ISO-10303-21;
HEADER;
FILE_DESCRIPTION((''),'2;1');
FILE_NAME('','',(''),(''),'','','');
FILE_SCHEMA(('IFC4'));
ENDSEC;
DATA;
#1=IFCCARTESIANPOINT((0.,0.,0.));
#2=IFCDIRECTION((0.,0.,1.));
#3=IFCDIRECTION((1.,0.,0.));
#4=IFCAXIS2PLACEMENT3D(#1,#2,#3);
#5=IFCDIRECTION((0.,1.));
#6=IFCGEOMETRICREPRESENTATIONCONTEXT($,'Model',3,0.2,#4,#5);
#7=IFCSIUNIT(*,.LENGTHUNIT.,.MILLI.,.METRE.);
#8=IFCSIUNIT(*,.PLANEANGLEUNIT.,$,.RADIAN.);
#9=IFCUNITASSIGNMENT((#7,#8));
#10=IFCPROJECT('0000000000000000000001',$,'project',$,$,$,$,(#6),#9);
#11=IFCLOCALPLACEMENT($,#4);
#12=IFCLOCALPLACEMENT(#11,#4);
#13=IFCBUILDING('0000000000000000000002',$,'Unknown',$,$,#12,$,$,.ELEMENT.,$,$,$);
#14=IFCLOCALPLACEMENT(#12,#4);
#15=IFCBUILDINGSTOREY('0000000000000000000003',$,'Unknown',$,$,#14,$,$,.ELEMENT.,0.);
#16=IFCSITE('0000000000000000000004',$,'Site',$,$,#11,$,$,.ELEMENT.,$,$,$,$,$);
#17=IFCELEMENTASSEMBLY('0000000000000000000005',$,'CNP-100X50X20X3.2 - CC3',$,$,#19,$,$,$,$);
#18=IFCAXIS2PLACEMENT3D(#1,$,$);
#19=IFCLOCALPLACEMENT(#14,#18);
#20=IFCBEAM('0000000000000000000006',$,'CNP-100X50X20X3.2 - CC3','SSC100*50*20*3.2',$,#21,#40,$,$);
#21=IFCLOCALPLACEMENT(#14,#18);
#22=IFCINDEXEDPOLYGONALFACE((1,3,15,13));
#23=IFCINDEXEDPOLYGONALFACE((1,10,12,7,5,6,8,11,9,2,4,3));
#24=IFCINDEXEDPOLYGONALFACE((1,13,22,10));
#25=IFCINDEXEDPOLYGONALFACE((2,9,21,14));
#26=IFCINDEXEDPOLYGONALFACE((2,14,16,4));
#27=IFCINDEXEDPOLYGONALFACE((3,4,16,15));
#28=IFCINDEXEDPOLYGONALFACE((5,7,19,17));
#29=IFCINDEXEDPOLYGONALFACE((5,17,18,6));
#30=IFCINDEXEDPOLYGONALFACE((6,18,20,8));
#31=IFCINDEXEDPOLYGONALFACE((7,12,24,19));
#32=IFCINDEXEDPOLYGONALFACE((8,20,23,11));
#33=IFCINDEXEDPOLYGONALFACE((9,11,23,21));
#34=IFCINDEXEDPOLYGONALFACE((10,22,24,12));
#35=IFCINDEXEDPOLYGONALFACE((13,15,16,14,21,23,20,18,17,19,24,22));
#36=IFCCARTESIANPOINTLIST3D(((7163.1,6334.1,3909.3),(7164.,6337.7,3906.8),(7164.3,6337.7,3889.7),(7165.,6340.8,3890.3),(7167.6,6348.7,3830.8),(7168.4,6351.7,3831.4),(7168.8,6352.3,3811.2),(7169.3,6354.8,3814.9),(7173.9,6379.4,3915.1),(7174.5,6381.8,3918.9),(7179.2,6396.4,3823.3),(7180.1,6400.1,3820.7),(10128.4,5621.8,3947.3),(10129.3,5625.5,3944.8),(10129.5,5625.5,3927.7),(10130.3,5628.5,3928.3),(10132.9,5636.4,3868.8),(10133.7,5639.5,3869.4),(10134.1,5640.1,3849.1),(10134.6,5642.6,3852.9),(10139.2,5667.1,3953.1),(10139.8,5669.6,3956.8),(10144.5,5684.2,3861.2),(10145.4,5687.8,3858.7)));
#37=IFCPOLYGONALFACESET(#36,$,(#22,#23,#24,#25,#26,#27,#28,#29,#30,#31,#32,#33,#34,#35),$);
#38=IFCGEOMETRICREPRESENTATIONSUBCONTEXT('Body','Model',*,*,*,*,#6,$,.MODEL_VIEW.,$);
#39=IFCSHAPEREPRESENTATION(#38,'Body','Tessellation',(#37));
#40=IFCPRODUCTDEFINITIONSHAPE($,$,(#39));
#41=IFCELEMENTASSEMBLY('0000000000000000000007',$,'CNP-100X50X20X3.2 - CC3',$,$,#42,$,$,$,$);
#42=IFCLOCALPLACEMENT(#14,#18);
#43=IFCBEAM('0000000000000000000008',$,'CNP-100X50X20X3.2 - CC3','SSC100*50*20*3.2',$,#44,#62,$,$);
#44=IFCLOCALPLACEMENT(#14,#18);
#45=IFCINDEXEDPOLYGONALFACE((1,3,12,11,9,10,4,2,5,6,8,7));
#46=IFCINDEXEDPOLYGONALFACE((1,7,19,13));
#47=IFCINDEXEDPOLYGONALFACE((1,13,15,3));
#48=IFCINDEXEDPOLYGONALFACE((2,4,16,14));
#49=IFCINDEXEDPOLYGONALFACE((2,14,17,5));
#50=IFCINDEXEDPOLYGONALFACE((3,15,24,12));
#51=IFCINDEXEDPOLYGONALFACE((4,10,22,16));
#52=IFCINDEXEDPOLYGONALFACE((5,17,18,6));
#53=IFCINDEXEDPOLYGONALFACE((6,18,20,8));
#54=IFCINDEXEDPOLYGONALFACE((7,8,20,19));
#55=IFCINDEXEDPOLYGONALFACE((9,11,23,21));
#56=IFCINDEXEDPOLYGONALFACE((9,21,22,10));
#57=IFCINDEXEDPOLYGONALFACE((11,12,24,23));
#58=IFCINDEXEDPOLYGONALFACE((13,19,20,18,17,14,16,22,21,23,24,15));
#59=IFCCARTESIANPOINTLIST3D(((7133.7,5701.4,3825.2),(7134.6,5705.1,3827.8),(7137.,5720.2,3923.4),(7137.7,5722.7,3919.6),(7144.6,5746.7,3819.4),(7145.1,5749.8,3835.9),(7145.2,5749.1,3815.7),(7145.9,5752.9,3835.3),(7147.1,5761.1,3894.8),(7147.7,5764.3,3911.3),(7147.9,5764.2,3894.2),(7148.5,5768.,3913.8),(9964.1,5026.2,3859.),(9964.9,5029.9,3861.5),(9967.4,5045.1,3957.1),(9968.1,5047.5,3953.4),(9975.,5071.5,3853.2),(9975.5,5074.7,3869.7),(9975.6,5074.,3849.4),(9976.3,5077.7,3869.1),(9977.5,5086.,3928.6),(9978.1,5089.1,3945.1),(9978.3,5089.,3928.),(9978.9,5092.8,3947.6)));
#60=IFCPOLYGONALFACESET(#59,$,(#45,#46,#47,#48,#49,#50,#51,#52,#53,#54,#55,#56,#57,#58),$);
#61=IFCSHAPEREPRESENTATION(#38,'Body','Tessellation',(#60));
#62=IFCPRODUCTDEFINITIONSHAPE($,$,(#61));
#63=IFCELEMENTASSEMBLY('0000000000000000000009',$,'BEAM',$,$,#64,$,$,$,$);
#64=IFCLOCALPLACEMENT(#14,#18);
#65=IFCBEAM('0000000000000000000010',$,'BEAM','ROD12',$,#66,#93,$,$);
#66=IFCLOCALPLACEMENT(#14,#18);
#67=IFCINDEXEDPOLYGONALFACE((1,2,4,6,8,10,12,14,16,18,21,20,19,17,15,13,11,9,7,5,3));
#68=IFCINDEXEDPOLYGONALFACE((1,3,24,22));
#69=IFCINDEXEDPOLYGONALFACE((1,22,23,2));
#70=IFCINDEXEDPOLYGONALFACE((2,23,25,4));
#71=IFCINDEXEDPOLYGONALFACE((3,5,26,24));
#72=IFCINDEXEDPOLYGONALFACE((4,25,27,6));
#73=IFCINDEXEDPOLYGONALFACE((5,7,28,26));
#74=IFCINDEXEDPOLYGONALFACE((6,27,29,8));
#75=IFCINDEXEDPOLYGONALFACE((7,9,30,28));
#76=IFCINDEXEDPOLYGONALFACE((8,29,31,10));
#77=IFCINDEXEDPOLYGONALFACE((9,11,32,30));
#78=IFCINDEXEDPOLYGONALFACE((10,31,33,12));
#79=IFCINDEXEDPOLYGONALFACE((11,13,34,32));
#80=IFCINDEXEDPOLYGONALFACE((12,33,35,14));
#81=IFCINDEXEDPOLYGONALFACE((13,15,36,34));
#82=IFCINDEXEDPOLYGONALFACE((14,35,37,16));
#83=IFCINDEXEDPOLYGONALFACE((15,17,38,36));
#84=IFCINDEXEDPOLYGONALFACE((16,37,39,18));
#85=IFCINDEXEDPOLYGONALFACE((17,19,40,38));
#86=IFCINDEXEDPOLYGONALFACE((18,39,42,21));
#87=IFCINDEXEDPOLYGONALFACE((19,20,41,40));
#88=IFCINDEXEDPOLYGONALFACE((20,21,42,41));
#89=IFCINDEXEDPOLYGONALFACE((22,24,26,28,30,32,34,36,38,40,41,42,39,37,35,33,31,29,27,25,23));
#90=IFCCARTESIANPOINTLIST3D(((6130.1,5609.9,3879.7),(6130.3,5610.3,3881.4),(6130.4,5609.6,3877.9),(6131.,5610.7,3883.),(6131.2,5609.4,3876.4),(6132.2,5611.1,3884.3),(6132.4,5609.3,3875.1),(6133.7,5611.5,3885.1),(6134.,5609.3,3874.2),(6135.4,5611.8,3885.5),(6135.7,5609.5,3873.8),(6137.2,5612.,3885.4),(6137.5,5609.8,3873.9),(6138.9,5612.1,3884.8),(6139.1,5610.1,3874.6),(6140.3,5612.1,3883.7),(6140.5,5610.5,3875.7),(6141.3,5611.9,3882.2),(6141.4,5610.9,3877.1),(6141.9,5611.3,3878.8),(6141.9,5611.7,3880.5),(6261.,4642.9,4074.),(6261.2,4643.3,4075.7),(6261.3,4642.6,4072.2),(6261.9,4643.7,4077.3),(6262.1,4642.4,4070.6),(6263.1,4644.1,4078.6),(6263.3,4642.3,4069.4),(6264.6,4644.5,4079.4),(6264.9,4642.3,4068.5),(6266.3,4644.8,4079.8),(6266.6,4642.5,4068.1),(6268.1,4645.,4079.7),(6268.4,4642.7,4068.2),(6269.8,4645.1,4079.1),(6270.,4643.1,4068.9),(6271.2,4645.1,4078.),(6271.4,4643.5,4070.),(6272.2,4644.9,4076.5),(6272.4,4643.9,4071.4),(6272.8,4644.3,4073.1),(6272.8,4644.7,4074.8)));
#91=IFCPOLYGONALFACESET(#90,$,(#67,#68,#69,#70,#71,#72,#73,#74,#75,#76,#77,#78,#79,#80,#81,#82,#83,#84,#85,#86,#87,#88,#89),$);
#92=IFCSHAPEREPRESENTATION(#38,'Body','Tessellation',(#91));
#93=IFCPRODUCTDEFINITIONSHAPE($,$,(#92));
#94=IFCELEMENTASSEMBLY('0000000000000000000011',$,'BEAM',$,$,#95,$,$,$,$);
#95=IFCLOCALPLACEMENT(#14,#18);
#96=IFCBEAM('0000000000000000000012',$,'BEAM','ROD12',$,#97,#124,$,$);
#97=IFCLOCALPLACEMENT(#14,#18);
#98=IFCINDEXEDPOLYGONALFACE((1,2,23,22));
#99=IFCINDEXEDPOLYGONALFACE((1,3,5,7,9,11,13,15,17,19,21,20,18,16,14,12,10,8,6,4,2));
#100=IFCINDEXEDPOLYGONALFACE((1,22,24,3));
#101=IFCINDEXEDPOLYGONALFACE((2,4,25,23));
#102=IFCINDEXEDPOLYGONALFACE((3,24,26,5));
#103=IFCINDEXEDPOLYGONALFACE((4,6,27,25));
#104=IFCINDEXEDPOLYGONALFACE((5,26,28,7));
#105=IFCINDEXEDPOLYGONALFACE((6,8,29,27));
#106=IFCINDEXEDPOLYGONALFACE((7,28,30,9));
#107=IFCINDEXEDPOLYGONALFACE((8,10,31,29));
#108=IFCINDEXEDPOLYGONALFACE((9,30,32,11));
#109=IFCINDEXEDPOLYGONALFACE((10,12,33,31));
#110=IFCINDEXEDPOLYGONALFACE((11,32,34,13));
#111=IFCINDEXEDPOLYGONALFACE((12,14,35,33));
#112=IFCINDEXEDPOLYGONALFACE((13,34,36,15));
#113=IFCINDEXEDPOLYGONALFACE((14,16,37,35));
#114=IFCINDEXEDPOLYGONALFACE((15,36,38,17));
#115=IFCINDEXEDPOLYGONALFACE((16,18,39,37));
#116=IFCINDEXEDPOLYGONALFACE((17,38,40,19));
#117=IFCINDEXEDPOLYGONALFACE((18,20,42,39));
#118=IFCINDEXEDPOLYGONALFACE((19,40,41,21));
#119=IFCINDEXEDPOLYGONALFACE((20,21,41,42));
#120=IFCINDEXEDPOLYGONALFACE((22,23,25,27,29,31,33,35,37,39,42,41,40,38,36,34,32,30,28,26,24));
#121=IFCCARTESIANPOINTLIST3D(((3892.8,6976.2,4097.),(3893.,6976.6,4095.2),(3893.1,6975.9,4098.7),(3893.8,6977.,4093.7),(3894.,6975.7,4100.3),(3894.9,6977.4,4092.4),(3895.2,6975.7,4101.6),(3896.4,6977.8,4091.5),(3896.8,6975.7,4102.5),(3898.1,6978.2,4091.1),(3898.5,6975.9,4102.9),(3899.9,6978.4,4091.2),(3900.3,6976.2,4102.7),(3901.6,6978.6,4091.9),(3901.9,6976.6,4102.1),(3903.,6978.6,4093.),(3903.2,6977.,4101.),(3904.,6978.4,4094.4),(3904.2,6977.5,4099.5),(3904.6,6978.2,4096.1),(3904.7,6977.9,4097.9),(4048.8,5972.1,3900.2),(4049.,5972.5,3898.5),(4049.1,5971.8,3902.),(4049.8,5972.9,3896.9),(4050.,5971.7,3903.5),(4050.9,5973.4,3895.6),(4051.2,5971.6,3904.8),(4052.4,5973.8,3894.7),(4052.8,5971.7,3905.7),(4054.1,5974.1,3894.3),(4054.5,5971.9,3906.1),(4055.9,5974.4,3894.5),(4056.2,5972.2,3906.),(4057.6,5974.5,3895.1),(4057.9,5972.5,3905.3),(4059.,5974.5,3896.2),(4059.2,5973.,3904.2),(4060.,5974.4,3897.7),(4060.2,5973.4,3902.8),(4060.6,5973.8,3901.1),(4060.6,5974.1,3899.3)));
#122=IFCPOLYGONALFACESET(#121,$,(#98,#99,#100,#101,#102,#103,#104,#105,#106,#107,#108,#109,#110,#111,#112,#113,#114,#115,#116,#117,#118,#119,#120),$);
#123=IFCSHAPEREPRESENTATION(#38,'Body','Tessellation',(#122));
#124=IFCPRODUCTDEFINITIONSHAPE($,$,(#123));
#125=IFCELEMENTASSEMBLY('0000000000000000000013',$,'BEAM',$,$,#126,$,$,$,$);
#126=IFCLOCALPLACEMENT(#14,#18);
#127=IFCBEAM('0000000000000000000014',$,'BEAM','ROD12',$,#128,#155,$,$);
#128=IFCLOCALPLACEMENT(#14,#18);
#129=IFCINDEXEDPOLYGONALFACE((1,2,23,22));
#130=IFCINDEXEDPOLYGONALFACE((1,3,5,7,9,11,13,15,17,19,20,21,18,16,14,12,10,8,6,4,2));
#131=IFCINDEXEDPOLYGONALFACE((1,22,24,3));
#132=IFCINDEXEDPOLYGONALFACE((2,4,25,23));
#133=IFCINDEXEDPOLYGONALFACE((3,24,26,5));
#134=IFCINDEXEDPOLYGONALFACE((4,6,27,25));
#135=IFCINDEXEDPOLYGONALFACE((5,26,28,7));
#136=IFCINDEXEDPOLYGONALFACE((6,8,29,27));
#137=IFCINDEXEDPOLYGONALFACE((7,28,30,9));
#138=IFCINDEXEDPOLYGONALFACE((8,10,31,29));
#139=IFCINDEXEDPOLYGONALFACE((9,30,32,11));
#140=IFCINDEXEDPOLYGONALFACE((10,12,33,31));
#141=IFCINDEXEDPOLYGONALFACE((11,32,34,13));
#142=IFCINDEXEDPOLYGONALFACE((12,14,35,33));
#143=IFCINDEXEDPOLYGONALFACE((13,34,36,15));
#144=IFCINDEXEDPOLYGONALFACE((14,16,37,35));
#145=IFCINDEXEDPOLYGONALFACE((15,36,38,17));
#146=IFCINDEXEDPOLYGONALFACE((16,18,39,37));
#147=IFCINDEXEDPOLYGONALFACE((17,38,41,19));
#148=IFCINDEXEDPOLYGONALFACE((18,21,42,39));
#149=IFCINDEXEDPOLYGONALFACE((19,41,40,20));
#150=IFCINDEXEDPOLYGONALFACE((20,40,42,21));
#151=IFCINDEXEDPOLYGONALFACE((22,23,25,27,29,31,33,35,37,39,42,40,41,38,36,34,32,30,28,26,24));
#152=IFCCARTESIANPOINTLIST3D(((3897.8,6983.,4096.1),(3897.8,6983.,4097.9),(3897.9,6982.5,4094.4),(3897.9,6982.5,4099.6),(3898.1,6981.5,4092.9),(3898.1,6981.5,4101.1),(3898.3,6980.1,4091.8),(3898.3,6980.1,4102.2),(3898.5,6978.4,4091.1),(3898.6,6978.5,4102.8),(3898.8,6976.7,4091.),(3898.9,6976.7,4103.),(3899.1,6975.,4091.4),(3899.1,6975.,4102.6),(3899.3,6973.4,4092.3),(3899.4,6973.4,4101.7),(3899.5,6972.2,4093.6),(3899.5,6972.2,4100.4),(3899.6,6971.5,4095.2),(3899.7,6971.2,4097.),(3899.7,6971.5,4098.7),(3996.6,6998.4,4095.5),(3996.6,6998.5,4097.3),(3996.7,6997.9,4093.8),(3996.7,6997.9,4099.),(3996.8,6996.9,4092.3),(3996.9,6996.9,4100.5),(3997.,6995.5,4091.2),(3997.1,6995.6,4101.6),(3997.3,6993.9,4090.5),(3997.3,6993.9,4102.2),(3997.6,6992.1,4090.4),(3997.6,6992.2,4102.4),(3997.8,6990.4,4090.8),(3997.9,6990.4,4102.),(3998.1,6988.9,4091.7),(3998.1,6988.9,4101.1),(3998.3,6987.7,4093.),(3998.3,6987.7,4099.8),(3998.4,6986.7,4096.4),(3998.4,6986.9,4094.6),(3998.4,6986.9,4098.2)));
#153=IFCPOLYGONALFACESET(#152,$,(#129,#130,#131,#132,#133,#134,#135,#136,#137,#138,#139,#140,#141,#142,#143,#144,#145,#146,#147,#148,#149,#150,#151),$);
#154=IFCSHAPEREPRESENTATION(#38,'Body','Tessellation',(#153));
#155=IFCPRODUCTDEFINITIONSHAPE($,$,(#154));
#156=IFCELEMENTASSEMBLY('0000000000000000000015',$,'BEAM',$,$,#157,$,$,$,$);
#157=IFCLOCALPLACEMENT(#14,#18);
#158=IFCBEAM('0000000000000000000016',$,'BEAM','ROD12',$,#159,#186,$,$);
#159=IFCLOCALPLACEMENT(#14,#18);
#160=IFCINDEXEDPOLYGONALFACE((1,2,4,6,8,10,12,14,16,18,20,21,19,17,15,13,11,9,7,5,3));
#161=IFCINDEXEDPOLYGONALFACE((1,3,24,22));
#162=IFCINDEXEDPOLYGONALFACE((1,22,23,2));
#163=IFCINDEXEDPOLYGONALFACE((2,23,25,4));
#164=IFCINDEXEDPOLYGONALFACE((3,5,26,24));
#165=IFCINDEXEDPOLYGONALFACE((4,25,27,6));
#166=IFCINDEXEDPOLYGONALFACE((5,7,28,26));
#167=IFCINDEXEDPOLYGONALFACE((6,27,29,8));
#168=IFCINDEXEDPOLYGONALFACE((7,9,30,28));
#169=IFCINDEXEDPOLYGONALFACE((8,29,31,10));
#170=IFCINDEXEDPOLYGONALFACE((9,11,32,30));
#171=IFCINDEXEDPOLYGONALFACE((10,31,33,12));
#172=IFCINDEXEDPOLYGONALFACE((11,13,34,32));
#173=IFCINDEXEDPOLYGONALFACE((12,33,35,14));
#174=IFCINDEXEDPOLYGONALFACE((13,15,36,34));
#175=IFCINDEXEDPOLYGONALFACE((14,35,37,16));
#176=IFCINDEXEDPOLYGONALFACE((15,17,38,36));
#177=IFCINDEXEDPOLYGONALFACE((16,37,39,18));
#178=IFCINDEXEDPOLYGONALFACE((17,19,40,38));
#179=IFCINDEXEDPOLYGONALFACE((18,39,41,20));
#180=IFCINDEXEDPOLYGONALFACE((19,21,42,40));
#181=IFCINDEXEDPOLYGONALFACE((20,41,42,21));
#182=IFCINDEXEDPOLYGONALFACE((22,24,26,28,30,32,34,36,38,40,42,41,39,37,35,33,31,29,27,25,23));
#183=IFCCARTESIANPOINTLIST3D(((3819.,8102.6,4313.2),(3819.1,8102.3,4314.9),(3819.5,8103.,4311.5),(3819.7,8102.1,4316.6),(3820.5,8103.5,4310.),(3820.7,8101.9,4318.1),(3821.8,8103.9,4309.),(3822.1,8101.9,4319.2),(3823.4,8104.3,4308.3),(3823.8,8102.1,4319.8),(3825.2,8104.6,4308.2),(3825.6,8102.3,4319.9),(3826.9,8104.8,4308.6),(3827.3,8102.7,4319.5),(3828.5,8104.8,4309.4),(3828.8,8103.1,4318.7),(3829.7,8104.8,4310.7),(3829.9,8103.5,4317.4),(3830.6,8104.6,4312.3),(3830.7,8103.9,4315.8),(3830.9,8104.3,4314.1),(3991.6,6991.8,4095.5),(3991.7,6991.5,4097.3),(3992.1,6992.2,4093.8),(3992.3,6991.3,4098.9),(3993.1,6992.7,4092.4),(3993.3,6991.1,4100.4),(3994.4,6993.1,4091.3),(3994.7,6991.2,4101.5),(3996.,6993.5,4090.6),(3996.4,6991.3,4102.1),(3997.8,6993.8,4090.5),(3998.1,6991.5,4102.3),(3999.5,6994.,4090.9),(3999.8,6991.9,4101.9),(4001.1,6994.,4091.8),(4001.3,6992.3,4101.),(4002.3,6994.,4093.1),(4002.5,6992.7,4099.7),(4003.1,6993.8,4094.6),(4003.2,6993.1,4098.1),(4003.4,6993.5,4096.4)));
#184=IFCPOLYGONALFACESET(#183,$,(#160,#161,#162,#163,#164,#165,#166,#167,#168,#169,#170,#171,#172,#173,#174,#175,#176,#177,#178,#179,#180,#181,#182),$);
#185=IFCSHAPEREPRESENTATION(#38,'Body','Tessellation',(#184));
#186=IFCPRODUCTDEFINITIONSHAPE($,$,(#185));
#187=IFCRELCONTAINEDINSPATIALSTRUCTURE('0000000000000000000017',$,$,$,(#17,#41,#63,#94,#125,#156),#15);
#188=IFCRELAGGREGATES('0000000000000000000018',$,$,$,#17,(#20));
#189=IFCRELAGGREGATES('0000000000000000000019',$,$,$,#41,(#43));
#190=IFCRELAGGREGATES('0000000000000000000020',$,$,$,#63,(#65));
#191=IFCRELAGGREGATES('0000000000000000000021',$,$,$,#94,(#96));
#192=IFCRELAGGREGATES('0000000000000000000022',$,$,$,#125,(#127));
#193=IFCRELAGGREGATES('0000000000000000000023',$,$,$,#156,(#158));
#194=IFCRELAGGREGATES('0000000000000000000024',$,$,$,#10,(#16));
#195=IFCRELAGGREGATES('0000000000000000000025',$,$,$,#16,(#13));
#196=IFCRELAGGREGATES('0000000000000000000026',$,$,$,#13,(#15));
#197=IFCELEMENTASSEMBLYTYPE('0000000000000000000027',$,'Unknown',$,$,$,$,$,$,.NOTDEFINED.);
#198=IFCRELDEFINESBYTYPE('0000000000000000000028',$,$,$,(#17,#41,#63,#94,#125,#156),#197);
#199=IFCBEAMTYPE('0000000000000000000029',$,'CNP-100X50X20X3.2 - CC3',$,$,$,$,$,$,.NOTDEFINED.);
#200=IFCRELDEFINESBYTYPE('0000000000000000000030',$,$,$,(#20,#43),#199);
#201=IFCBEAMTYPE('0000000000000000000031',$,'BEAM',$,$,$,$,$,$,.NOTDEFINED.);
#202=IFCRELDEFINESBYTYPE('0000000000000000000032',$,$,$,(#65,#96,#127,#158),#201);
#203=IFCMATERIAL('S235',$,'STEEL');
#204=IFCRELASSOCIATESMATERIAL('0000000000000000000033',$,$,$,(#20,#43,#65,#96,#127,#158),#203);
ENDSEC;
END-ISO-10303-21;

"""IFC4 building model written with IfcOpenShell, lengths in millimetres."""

from ifc_helpers import new_model, si_unit, direction, frame, origin_with_axes, origin_2d_with_axis, place, context, subcontext, project, spatial, circle, c_section, extrude, material, material_profile, profile_set, profile_usage, type_object, element, aggregate, save


model = new_model("IFC4")

# Units and contexts
model_context = context("Model", 3, precision=0.2, world=origin_with_axes(), true_north=direction((0.0, 1.0)))
body_context = subcontext(model_context, "Body", "Model", "MODEL_VIEW")
ifc_project = project(units=[si_unit("LENGTHUNIT", "METRE", prefix="MILLI"), si_unit("PLANEANGLEUNIT", "RADIAN")], contexts=[model_context])

# Site, building, storey
site_placement = place(None, origin_with_axes())
site = spatial("IfcSite", under=ifc_project, at=site_placement, Name="Site", CompositionType="ELEMENT")
building_placement = place(site_placement, origin_with_axes())
building = spatial("IfcBuilding", under=site, at=building_placement, Name="Unknown", CompositionType="ELEMENT")
storey_placement = place(building_placement, origin_with_axes())
storey = spatial("IfcBuildingStorey", under=building, at=storey_placement, Name="Unknown", CompositionType="ELEMENT", Elevation=0.0)

# Element assemblies, beams
element_assembly_type = type_object("IfcElementAssemblyType", Name="Unknown", PredefinedType="NOTDEFINED")
assembly_1_placement = place(storey_placement, frame((7171.6, 6367.1, 3865.0), z_axis=(-0.226954, -0.955034, -0.190794), x_axis=(0.972269, -0.233535, 0.012439)))
assembly_1 = element("IfcElementAssembly", 1, at=assembly_1_placement, inside=storey, type_object=element_assembly_type, Name="CNP-100X50X20X3.2 - CC3")
ifc_material_1 = material(Name="S235", Category="STEEL")
ifc_material_profile_1 = material_profile(ifc_material_1, c_section(Depth=100.0, Width=50.0, WallThickness=3.2, Girth=20.0, at=origin_2d_with_axis()), Name="SSC100*50*20*3.2")
ifc_profile_set_1 = profile_set([ifc_material_profile_1])
ifc_profile_usage_1 = profile_usage(ifc_profile_set_1, cardinal=4)
beam_type_1 = type_object("IfcBeamType", Name="CNP-100X50X20X3.2 - CC3", PredefinedType="NOTDEFINED")
beam_1_placement = place(assembly_1_placement, origin_with_axes())
beam_1 = element("IfcBeam", 2, at=beam_1_placement, type_object=beam_type_1, material=ifc_profile_usage_1, Name="CNP-100X50X20X3.2 - CC3", Description="SSC100*50*20*3.2", context=body_context, shape_type="SolidModel", body=[
    extrude(c_section(Depth=100.0, Width=50.0, WallThickness=3.2, Girth=20.0, at=origin_2d_with_axis()), frame((0.0, 0.0, 0.0), z_axis=(-1.0, 0.0, 0.0), x_axis=(0.0, 0.0, 1.0)), (0.0, 0.0, -1.0), 3049.9),
])
aggregate(assembly_1, [beam_1])
assembly_2_placement = place(storey_placement, frame((7141.1, 5734.7, 3869.5), z_axis=(0.22992, 0.954324, -0.190796), x_axis=(0.972643, -0.232015, 0.011599)))
assembly_2 = element("IfcElementAssembly", 3, at=assembly_2_placement, inside=storey, type_object=element_assembly_type, Name="CNP-100X50X20X3.2 - CC3")
beam_2_placement = place(assembly_2_placement, origin_with_axes())
beam_2 = element("IfcBeam", 4, at=beam_2_placement, type_object=beam_type_1, material=ifc_profile_usage_1, Name="CNP-100X50X20X3.2 - CC3", Description="SSC100*50*20*3.2", context=body_context, shape_type="SolidModel", body=[
    extrude(c_section(Depth=100.0, Width=50.0, WallThickness=3.2, Girth=20.0, at=origin_2d_with_axis()), frame((0.0, 0.0, 0.0), z_axis=(-1.0, 0.0, 0.0), x_axis=(0.0, 0.0, 1.0)), (0.0, 0.0, -1.0), 2910.0),
])
aggregate(assembly_2, [beam_2])
assembly_3_placement = place(storey_placement, frame((6136.0, 5610.7, 3879.7), z_axis=(-0.99096, -0.134155, 0.0), x_axis=(0.131572, -0.971884, 0.195271)))
assembly_3 = element("IfcElementAssembly", 5, at=assembly_3_placement, inside=storey, type_object=element_assembly_type, Name="BEAM")
ifc_material_profile_2 = material_profile(ifc_material_1, circle(Radius=6.0, at=origin_2d_with_axis()), Name="ROD12")
ifc_profile_set_2 = profile_set([ifc_material_profile_2])
ifc_profile_usage_2 = profile_usage(ifc_profile_set_2, cardinal=5)
beam_type_2 = type_object("IfcBeamType", Name="BEAM", PredefinedType="NOTDEFINED")
beam_3_placement = place(assembly_3_placement, origin_with_axes())
beam_3 = element("IfcBeam", 6, at=beam_3_placement, type_object=beam_type_2, material=ifc_profile_usage_2, Name="BEAM", Description="ROD12", context=body_context, shape_type="SolidModel", body=[
    extrude(circle(Radius=6.0, at=origin_2d_with_axis()), frame((0.0, 0.0, 0.0), z_axis=(-1.0, 0.0, 0.0), x_axis=(0.0, 0.0, 1.0)), (0.0, 0.0, -1.0), 995.0),
])
aggregate(assembly_3, [beam_3])
assembly_4_placement = place(storey_placement, frame((3898.8, 6977.1, 4097.0), z_axis=(-0.988145, -0.153522, 0.0), x_axis=(0.150723, -0.970125, -0.190107)))
assembly_4 = element("IfcElementAssembly", 7, at=assembly_4_placement, inside=storey, type_object=element_assembly_type, Name="BEAM")
beam_4_placement = place(assembly_4_placement, origin_with_axes())
beam_4 = element("IfcBeam", 8, at=beam_4_placement, type_object=beam_type_2, material=ifc_profile_usage_2, Name="BEAM", Description="ROD12", context=body_context, shape_type="SolidModel", body=[
    extrude(circle(Radius=6.0, at=origin_2d_with_axis()), frame((0.0, 0.0, 0.0), z_axis=(-1.0, 0.0, 0.0), x_axis=(0.0, 0.0, 1.0)), (0.0, 0.0, -1.0), 1035.0),
])
aggregate(assembly_4, [beam_4])
assembly_5_placement = place(storey_placement, frame((3898.8, 6977.1, 4097.0), z_axis=(0.154668, -0.987966, 0.0), x_axis=(0.987949, 0.154665, -0.005988)))
assembly_5 = element("IfcElementAssembly", 9, at=assembly_5_placement, inside=storey, type_object=element_assembly_type, Name="BEAM")
beam_5_placement = place(assembly_5_placement, origin_with_axes())
beam_5 = element("IfcBeam", 10, at=beam_5_placement, type_object=beam_type_2, material=ifc_profile_usage_2, Name="BEAM", Description="ROD12", context=body_context, shape_type="SolidModel", body=[
    extrude(circle(Radius=6.0, at=origin_2d_with_axis()), frame((0.0, 0.0, 0.0), z_axis=(-1.0, 0.0, 0.0), x_axis=(0.0, 0.0, 1.0)), (0.0, 0.0, -1.0), 100.0),
])
aggregate(assembly_5, [beam_5])
assembly_6_placement = place(storey_placement, frame((3997.5, 6992.6, 4096.4), z_axis=(0.988145, 0.153522, 0.0), x_axis=(-0.150723, 0.970125, 0.190107)))
assembly_6 = element("IfcElementAssembly", 11, at=assembly_6_placement, inside=storey, type_object=element_assembly_type, Name="BEAM")
beam_6_placement = place(assembly_6_placement, origin_with_axes())
beam_6 = element("IfcBeam", 12, at=beam_6_placement, type_object=beam_type_2, material=ifc_profile_usage_2, Name="BEAM", Description="ROD12", context=body_context, shape_type="SolidModel", body=[
    extrude(circle(Radius=6.0, at=origin_2d_with_axis()), frame((0.0, 0.0, 0.0), z_axis=(-1.0, 0.0, 0.0), x_axis=(0.0, 0.0, 1.0)), (0.0, 0.0, -1.0), 1145.0),
])
aggregate(assembly_6, [beam_6])

save(model, "model.ifc")
